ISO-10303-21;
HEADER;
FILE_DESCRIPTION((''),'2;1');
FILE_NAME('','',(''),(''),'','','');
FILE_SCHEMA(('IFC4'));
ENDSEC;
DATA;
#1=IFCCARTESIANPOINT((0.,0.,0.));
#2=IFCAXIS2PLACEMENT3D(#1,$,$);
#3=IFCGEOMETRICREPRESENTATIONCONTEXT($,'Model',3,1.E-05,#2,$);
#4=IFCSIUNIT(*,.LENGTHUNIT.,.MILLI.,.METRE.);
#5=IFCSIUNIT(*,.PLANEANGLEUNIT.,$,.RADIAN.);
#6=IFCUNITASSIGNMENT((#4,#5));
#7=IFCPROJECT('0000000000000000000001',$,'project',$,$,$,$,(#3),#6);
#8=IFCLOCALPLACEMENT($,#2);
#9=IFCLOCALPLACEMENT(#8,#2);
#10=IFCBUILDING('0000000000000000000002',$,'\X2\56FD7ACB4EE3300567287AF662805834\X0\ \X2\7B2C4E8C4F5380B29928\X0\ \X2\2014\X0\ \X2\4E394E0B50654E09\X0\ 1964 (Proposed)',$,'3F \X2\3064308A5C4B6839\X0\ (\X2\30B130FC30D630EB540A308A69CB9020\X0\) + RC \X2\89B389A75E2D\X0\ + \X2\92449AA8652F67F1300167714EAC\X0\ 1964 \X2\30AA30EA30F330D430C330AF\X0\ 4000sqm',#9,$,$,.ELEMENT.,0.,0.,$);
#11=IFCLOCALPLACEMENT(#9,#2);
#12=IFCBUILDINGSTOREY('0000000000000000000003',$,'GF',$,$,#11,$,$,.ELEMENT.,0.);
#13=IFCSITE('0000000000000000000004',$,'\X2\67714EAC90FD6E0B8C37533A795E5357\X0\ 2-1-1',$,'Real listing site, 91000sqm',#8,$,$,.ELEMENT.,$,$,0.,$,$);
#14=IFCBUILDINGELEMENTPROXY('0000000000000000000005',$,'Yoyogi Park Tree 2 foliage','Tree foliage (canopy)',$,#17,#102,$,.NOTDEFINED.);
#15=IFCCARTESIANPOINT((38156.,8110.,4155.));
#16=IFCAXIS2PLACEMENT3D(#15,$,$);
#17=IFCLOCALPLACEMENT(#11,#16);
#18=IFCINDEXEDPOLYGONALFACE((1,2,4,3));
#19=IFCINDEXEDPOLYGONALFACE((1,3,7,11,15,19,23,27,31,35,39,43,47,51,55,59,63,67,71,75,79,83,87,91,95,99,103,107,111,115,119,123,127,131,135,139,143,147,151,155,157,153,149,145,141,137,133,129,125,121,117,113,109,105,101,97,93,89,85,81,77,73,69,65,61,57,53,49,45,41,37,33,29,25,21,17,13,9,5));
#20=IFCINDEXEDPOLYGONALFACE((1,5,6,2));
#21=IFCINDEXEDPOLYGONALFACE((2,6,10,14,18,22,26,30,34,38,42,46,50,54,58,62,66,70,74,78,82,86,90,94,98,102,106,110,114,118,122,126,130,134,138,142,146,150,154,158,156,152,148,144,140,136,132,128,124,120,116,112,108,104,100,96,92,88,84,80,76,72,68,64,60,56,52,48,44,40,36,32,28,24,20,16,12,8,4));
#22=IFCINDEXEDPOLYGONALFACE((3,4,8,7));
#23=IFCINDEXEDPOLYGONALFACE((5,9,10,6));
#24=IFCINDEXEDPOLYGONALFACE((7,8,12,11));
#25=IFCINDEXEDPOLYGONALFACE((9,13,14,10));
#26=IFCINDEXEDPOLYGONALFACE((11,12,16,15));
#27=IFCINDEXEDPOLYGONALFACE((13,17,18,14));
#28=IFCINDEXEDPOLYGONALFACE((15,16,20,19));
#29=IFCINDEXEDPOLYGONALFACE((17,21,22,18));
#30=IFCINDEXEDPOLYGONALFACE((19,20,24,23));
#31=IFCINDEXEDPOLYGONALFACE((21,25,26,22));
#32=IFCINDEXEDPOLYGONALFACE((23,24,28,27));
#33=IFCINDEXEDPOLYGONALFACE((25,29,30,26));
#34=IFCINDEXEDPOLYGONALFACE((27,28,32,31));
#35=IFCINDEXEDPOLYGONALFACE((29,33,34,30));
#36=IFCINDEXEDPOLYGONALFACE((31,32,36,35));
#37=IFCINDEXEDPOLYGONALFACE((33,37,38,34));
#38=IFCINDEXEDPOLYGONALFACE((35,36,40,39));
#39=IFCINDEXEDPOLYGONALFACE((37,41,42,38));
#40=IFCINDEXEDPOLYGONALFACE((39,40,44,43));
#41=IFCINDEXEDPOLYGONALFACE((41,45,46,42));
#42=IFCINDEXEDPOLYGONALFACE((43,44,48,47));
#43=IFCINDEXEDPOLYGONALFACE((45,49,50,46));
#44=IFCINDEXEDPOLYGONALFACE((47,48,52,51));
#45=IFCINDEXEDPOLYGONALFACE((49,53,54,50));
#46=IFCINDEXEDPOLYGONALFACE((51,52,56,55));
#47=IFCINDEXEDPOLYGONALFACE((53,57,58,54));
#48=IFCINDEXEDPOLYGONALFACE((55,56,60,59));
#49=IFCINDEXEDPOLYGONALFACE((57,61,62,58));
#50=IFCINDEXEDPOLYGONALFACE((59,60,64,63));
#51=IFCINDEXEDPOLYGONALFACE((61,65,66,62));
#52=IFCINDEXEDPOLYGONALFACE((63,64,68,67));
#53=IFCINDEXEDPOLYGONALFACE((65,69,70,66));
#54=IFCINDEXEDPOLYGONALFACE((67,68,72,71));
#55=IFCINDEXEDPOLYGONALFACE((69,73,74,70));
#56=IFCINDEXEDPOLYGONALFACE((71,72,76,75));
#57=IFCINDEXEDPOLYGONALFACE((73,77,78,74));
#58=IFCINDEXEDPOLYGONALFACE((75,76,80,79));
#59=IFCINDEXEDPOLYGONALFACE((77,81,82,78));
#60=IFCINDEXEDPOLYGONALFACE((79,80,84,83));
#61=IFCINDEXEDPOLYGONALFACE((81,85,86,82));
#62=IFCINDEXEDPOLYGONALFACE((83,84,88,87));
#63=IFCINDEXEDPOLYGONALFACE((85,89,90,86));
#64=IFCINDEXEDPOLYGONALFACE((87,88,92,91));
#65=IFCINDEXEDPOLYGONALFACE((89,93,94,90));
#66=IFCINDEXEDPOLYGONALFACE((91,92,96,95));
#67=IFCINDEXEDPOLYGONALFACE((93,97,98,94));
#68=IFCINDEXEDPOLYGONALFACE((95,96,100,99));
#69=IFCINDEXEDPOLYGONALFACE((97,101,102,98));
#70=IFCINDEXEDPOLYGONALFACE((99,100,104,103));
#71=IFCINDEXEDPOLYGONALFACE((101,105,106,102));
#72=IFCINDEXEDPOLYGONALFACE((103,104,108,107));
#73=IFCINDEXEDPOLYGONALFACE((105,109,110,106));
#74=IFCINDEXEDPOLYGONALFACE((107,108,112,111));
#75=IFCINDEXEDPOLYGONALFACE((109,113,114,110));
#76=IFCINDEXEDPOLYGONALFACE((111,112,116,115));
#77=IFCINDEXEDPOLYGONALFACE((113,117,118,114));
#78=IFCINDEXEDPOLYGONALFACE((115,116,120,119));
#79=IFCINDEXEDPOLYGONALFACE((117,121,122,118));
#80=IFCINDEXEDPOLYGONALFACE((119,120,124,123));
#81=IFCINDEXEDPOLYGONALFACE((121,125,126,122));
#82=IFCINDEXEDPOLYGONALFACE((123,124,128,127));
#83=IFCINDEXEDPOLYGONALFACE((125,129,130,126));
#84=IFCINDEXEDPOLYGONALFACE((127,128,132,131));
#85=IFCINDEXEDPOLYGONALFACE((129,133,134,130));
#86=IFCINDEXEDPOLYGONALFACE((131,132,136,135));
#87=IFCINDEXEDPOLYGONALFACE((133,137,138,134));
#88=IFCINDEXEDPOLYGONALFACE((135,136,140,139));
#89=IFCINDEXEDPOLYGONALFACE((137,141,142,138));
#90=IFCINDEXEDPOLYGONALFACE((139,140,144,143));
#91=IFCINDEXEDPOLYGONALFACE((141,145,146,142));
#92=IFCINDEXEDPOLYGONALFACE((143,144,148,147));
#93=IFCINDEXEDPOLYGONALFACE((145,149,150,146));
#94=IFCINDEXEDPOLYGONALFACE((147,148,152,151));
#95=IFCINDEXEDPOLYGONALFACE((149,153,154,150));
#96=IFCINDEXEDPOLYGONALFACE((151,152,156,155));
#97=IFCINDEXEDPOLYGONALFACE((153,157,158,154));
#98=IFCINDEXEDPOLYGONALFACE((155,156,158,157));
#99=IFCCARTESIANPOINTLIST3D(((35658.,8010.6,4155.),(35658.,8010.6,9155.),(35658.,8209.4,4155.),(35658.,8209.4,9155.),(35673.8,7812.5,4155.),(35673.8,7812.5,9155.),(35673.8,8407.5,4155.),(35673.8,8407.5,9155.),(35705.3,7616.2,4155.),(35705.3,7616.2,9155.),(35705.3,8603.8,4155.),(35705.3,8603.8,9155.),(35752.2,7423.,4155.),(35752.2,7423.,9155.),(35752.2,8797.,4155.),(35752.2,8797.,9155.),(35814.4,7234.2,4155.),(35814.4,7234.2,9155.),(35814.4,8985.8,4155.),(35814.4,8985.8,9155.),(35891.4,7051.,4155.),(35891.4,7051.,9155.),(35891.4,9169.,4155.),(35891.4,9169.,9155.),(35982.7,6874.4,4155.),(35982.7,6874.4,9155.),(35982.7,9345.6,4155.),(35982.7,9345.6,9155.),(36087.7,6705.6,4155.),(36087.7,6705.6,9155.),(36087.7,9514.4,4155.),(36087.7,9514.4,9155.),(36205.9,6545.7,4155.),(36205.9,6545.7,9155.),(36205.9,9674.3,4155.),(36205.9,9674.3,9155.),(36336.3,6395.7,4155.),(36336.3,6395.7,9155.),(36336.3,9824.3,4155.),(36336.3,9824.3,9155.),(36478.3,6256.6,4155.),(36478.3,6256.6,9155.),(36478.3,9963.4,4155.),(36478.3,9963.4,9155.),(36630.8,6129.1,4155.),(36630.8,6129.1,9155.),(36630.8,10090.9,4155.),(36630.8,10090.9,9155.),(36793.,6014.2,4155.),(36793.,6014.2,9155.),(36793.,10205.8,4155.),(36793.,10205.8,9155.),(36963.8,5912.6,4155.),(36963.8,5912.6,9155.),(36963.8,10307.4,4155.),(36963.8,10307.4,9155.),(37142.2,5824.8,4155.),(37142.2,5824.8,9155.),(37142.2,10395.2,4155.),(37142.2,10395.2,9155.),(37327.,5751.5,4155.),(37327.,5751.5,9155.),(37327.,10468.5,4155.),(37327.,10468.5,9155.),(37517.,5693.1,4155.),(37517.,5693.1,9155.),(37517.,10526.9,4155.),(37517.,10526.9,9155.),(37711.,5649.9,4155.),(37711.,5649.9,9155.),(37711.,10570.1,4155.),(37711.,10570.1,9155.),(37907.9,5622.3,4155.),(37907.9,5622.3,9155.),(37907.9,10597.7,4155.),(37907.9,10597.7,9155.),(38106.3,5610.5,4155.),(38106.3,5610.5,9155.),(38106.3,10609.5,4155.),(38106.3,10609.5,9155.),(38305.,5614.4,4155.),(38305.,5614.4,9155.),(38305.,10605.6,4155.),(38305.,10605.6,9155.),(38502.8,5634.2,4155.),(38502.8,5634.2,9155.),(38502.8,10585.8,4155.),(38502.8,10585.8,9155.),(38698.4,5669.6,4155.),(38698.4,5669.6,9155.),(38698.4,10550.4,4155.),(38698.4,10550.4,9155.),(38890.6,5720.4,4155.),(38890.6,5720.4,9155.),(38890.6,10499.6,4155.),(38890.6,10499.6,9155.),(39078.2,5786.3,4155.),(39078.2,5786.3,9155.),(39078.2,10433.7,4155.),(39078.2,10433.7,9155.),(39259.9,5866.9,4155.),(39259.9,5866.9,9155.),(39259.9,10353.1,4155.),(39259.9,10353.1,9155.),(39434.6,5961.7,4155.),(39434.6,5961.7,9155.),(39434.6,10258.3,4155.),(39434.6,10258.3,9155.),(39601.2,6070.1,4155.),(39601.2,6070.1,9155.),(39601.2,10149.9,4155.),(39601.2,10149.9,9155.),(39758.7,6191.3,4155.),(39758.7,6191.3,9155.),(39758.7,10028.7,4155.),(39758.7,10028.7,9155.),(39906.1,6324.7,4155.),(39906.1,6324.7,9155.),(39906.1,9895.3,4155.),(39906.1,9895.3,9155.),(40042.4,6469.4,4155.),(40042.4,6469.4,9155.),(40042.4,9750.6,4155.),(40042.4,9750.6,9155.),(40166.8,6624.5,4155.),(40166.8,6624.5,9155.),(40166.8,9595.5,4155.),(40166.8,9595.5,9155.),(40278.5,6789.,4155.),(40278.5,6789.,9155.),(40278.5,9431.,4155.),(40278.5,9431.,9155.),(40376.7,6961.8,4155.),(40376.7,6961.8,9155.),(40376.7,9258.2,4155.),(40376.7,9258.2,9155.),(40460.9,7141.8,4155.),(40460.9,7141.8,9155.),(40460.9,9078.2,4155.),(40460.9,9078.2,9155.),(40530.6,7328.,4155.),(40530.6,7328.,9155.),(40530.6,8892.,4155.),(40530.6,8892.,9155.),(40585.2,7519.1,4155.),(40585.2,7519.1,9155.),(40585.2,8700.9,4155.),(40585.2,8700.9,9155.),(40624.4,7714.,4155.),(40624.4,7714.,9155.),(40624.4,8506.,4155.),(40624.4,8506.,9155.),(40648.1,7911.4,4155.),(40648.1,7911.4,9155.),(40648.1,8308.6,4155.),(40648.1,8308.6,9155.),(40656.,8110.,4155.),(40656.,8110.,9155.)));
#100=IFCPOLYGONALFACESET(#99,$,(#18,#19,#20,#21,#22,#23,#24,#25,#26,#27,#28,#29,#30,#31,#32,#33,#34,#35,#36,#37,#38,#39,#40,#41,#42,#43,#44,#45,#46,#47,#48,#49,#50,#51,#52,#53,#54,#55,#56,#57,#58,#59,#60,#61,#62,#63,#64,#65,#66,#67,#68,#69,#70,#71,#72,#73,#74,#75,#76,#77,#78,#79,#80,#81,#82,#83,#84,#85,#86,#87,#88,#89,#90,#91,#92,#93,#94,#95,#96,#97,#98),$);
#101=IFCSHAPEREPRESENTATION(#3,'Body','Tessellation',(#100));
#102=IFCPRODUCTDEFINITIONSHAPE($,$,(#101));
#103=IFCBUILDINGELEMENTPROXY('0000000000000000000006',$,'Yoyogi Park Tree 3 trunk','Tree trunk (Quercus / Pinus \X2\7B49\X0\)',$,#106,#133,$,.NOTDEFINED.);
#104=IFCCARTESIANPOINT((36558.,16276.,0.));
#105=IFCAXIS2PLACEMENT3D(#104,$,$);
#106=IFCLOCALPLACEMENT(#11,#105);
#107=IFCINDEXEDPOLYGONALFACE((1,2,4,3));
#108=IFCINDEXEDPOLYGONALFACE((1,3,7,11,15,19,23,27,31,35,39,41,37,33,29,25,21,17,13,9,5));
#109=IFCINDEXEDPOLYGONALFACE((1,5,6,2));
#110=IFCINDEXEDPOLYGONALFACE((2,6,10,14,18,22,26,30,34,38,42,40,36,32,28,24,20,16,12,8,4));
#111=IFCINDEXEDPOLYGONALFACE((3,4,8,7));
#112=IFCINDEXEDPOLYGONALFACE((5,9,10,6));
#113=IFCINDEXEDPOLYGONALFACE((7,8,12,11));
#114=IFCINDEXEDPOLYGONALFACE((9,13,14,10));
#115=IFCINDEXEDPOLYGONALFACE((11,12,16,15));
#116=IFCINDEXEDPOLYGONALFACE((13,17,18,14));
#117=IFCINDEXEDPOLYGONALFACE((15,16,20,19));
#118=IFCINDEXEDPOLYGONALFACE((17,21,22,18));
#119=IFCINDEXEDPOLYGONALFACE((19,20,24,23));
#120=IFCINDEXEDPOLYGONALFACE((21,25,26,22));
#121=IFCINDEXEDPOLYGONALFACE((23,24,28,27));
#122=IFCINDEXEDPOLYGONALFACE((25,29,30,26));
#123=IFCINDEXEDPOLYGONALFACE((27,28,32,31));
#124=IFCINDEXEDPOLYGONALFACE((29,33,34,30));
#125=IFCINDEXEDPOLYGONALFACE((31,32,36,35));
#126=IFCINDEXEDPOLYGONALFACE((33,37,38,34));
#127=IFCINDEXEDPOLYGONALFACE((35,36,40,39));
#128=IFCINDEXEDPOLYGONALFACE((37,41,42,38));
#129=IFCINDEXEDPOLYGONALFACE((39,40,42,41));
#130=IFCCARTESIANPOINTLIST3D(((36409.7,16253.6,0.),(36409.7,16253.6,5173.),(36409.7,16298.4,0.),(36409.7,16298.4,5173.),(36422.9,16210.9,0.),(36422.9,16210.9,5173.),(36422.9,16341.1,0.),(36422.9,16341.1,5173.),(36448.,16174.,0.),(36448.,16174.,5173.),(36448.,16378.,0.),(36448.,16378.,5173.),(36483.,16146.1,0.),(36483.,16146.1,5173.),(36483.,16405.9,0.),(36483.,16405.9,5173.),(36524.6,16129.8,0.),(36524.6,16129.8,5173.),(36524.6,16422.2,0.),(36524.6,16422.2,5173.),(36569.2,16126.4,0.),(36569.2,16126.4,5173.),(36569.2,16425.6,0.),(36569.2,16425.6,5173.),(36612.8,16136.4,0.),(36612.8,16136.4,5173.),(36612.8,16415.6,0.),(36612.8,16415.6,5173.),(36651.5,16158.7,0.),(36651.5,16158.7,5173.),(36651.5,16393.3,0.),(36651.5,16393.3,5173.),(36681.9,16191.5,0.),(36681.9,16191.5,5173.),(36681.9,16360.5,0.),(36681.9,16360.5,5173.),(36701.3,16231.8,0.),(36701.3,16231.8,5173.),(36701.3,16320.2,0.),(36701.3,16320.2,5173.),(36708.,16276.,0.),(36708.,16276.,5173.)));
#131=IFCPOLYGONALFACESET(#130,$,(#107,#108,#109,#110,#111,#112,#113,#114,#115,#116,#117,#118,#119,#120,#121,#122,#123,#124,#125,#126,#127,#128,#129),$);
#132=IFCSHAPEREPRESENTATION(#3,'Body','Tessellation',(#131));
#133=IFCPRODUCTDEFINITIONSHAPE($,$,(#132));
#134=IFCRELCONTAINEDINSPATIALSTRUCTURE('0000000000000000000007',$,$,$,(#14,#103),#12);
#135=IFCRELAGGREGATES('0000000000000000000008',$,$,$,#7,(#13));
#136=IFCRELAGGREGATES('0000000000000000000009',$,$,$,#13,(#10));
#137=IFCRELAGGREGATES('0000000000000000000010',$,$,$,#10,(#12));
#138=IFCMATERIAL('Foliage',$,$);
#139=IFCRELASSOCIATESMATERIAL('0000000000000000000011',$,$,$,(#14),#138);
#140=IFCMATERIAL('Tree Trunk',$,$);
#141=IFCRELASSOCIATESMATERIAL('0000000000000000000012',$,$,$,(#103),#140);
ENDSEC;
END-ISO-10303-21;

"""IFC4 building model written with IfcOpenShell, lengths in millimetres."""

from ifc_helpers import new_model, si_unit, frame, origin, origin_2d, place, context, project, spatial, circle, extrude, material, element, save


model = new_model("IFC4")

# Units and contexts
model_context = context("Model", 3, precision=1e-05, world=origin())
ifc_project = project(units=[si_unit("LENGTHUNIT", "METRE", prefix="MILLI"), si_unit("PLANEANGLEUNIT", "RADIAN")], contexts=[model_context])

# Site, building, storey
site_placement = place(None, origin())
site = spatial("IfcSite", under=ifc_project, at=site_placement, Name="東京都渋谷区神南 2-1-1", ObjectType="Real listing site, 91000sqm", CompositionType="ELEMENT", RefElevation=0.0)
building_placement = place(site_placement, origin())
building = spatial("IfcBuilding", under=site, at=building_placement, Name="国立代々木競技場 第二体育館 — 丹下健三 1964 (Proposed)", ObjectType="3F つり屋根 (ケーブル吊り構造) + RC 観覧席 + 鉄骨支柱、東京 1964 オリンピック 4000sqm", CompositionType="ELEMENT", ElevationOfRefHeight=0.0, ElevationOfTerrain=0.0)
storey_placement = place(building_placement, origin())
storey = spatial("IfcBuildingStorey", under=building, at=storey_placement, Name="GF", CompositionType="ELEMENT", Elevation=0.0)

# Building element proxies
ifc_material_1 = material(Name="Tree Trunk")
ifc_material_2 = material(Name="Foliage")
proxy_1_placement = place(storey_placement, frame((38156.0, 8110.0, 4155.0)))
element("IfcBuildingElementProxy", 1, at=proxy_1_placement, inside=storey, material=ifc_material_2, Name="Yoyogi Park Tree 2 foliage", Description="Tree foliage (canopy)", PredefinedType="NOTDEFINED", context=model_context, shape_type="SweptSolid", body=[
    extrude(circle(Radius=2500.0, at=origin_2d()), frame((38156.0, 8110.0, 4155.0)), (0.0, 0.0, 1.0), 5000.0),
])
proxy_2_placement = place(storey_placement, frame((36558.0, 16276.0, 0.0)))
element("IfcBuildingElementProxy", 2, at=proxy_2_placement, inside=storey, material=ifc_material_1, Name="Yoyogi Park Tree 3 trunk", Description="Tree trunk (Quercus / Pinus 等)", PredefinedType="NOTDEFINED", context=model_context, shape_type="SweptSolid", body=[
    extrude(circle(Radius=150.0, at=origin_2d()), frame((36558.0, 16276.0, 0.0)), (0.0, 0.0, 1.0), 5173.0),
])

save(model, "model.ifc")
